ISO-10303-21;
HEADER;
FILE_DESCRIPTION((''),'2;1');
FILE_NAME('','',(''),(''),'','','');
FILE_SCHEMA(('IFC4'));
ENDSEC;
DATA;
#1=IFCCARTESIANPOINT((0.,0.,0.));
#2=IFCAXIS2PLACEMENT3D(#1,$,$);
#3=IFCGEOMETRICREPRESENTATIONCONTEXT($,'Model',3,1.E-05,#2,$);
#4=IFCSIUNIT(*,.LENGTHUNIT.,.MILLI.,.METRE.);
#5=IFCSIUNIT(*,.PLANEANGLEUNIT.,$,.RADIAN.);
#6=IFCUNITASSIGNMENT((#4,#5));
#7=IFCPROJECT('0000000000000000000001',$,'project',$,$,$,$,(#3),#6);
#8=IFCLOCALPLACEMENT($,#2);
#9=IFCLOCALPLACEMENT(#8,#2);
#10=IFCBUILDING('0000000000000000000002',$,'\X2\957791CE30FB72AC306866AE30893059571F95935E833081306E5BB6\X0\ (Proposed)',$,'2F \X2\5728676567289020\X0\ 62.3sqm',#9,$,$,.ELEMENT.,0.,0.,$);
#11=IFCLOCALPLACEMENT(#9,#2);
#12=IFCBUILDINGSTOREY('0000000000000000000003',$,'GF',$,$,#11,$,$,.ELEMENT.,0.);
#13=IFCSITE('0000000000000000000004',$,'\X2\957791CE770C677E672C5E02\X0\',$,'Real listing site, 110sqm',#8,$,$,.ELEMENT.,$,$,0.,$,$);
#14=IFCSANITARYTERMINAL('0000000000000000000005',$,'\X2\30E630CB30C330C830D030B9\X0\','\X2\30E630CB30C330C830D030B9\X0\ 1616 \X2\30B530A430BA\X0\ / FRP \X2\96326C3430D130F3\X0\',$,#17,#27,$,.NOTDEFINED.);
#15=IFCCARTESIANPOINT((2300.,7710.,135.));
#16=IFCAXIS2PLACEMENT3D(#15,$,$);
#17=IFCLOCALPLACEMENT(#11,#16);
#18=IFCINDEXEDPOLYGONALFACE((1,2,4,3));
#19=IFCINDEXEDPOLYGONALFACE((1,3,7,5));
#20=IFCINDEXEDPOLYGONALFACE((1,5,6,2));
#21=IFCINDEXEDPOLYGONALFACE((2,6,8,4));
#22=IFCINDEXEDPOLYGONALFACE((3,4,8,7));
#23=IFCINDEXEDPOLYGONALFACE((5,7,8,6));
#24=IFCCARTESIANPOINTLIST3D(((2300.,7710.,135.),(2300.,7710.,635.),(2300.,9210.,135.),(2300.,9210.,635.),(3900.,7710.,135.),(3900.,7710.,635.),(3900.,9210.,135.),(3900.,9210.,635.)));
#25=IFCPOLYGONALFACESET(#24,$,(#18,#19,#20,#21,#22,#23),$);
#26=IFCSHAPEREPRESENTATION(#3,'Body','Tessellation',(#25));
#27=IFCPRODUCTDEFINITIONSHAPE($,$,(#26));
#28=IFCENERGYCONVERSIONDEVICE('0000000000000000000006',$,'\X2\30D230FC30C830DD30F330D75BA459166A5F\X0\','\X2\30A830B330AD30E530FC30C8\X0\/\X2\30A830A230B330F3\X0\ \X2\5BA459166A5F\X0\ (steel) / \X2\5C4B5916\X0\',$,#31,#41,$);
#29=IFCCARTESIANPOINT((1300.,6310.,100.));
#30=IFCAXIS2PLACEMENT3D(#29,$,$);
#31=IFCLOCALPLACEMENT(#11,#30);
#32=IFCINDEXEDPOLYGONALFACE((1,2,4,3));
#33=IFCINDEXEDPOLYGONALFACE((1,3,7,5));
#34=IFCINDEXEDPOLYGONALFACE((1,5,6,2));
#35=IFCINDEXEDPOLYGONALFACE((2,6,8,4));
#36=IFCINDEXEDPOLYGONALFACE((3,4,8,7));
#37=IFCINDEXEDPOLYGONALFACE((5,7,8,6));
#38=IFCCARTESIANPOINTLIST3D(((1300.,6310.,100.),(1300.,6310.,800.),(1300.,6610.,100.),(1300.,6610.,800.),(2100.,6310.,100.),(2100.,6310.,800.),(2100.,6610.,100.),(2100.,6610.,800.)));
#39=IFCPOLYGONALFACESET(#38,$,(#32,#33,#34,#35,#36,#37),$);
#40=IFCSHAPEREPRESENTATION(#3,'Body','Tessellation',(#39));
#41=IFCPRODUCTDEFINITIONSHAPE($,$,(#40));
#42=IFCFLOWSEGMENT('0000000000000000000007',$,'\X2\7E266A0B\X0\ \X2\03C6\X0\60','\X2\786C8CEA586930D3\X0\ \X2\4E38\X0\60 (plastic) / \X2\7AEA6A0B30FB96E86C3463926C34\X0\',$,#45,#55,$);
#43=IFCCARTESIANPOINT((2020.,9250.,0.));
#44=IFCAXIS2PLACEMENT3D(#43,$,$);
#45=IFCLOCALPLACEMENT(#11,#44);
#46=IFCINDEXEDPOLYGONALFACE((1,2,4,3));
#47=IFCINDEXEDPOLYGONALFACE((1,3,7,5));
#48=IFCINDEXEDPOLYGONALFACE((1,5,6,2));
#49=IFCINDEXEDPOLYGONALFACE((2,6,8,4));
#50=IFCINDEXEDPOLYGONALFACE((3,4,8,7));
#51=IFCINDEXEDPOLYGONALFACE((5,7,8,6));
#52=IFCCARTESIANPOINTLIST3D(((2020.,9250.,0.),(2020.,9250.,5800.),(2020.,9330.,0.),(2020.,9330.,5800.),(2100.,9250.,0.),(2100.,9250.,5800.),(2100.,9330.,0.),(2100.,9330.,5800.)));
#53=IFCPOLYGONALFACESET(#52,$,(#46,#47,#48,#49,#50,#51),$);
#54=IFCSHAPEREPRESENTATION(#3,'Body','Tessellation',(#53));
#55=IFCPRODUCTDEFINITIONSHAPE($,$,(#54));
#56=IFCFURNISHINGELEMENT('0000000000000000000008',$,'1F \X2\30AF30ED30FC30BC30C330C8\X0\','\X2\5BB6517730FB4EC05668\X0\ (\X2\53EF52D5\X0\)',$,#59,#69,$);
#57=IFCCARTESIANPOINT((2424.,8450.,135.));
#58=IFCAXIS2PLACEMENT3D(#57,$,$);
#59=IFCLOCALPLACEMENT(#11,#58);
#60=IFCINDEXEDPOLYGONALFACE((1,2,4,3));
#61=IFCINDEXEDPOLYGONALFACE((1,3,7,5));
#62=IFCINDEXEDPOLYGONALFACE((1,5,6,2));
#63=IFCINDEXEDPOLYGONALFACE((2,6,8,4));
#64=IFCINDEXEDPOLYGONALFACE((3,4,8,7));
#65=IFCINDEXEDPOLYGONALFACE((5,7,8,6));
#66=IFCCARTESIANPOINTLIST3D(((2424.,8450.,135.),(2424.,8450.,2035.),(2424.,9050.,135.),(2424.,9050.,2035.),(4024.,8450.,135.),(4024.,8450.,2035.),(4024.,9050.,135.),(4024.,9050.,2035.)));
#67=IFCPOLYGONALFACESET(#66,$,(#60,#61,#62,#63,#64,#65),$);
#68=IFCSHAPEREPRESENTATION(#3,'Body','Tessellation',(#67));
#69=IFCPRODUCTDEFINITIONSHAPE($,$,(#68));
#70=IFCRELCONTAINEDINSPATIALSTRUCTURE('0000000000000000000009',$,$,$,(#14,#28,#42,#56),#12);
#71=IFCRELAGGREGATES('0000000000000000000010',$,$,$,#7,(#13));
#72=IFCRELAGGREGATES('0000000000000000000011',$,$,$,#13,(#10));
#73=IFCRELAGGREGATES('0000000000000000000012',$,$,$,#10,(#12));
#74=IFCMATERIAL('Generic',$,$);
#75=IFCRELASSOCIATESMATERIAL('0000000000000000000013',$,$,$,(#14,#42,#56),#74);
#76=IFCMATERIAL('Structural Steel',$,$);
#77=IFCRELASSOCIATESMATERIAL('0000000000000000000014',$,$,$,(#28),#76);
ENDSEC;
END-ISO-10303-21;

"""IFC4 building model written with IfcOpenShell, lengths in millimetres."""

from ifc_helpers import new_model, si_unit, frame, frame_2d, origin, place, context, project, spatial, rectangle, extrude, material, element, save


model = new_model("IFC4")

# Units and contexts
model_context = context("Model", 3, precision=1e-05, world=origin())
ifc_project = project(units=[si_unit("LENGTHUNIT", "METRE", prefix="MILLI"), si_unit("PLANEANGLEUNIT", "RADIAN")], contexts=[model_context])

# Site, building, storey
site_placement = place(None, origin())
site = spatial("IfcSite", under=ifc_project, at=site_placement, Name="長野県松本市", ObjectType="Real listing site, 110sqm", CompositionType="ELEMENT", RefElevation=0.0)
building_placement = place(site_placement, origin())
building = spatial("IfcBuilding", under=site, at=building_placement, Name="長野・犬と暮らす土間広めの家 (Proposed)", ObjectType="2F 在来木造 62.3sqm", CompositionType="ELEMENT", ElevationOfRefHeight=0.0, ElevationOfTerrain=0.0)
storey_placement = place(building_placement, origin())
storey = spatial("IfcBuildingStorey", under=building, at=storey_placement, Name="GF", CompositionType="ELEMENT", Elevation=0.0)

# Shared definitions
ifc_material_1 = material(Name="Generic")

# Sanitary terminal
sanitary_terminal_placement = place(storey_placement, frame((2300.0, 7710.0, 135.0)))
element("IfcSanitaryTerminal", 1, at=sanitary_terminal_placement, inside=storey, material=ifc_material_1, Name="ユニットバス", Description="ユニットバス 1616 サイズ / FRP 防水パン", PredefinedType="NOTDEFINED", context=model_context, shape_type="SweptSolid", body=[
    extrude(rectangle(XDim=1600.0, YDim=1500.0, at=frame_2d((800.0, 750.0))), frame((2300.0, 7710.0, 135.0)), (0.0, 0.0, 1.0), 500.0),
])

# Energy conversion device
ifc_material_2 = material(Name="Structural Steel")
energy_conversion_device_placement = place(storey_placement, frame((1300.0, 6310.0, 100.0)))
element("IfcEnergyConversionDevice", 2, at=energy_conversion_device_placement, inside=storey, material=ifc_material_2, Name="ヒートポンプ室外機", Description="エコキュート/エアコン 室外機 (steel) / 屋外", context=model_context, shape_type="SweptSolid", body=[
    extrude(rectangle(XDim=800.0, YDim=300.0, at=frame_2d((400.0, 150.0))), frame((1300.0, 6310.0, 100.0)), (0.0, 0.0, 1.0), 700.0),
])

# Flow segment
flow_segment_placement = place(storey_placement, frame((2020.0, 9250.0, 0.0)))
element("IfcFlowSegment", 3, at=flow_segment_placement, inside=storey, material=ifc_material_1, Name="縦樋 φ60", Description="硬質塩ビ 丸60 (plastic) / 竪樋・雨水排水", context=model_context, shape_type="SweptSolid", body=[
    extrude(rectangle(XDim=80.0, YDim=80.0, at=frame_2d((40.0, 40.0))), frame((2020.0, 9250.0, 0.0)), (0.0, 0.0, 1.0), 5800.0),
])

# Furnishing element
furnishing_placement = place(storey_placement, frame((2424.0, 8450.0, 135.0)))
element("IfcFurnishingElement", 4, at=furnishing_placement, inside=storey, material=ifc_material_1, Name="1F クローゼット", Description="家具・什器 (可動)", context=model_context, shape_type="SweptSolid", body=[
    extrude(rectangle(XDim=1600.0, YDim=600.0, at=frame_2d((800.0, 300.0))), frame((2424.0, 8450.0, 135.0)), (0.0, 0.0, 1.0), 1900.0),
])

save(model, "model.ifc")
